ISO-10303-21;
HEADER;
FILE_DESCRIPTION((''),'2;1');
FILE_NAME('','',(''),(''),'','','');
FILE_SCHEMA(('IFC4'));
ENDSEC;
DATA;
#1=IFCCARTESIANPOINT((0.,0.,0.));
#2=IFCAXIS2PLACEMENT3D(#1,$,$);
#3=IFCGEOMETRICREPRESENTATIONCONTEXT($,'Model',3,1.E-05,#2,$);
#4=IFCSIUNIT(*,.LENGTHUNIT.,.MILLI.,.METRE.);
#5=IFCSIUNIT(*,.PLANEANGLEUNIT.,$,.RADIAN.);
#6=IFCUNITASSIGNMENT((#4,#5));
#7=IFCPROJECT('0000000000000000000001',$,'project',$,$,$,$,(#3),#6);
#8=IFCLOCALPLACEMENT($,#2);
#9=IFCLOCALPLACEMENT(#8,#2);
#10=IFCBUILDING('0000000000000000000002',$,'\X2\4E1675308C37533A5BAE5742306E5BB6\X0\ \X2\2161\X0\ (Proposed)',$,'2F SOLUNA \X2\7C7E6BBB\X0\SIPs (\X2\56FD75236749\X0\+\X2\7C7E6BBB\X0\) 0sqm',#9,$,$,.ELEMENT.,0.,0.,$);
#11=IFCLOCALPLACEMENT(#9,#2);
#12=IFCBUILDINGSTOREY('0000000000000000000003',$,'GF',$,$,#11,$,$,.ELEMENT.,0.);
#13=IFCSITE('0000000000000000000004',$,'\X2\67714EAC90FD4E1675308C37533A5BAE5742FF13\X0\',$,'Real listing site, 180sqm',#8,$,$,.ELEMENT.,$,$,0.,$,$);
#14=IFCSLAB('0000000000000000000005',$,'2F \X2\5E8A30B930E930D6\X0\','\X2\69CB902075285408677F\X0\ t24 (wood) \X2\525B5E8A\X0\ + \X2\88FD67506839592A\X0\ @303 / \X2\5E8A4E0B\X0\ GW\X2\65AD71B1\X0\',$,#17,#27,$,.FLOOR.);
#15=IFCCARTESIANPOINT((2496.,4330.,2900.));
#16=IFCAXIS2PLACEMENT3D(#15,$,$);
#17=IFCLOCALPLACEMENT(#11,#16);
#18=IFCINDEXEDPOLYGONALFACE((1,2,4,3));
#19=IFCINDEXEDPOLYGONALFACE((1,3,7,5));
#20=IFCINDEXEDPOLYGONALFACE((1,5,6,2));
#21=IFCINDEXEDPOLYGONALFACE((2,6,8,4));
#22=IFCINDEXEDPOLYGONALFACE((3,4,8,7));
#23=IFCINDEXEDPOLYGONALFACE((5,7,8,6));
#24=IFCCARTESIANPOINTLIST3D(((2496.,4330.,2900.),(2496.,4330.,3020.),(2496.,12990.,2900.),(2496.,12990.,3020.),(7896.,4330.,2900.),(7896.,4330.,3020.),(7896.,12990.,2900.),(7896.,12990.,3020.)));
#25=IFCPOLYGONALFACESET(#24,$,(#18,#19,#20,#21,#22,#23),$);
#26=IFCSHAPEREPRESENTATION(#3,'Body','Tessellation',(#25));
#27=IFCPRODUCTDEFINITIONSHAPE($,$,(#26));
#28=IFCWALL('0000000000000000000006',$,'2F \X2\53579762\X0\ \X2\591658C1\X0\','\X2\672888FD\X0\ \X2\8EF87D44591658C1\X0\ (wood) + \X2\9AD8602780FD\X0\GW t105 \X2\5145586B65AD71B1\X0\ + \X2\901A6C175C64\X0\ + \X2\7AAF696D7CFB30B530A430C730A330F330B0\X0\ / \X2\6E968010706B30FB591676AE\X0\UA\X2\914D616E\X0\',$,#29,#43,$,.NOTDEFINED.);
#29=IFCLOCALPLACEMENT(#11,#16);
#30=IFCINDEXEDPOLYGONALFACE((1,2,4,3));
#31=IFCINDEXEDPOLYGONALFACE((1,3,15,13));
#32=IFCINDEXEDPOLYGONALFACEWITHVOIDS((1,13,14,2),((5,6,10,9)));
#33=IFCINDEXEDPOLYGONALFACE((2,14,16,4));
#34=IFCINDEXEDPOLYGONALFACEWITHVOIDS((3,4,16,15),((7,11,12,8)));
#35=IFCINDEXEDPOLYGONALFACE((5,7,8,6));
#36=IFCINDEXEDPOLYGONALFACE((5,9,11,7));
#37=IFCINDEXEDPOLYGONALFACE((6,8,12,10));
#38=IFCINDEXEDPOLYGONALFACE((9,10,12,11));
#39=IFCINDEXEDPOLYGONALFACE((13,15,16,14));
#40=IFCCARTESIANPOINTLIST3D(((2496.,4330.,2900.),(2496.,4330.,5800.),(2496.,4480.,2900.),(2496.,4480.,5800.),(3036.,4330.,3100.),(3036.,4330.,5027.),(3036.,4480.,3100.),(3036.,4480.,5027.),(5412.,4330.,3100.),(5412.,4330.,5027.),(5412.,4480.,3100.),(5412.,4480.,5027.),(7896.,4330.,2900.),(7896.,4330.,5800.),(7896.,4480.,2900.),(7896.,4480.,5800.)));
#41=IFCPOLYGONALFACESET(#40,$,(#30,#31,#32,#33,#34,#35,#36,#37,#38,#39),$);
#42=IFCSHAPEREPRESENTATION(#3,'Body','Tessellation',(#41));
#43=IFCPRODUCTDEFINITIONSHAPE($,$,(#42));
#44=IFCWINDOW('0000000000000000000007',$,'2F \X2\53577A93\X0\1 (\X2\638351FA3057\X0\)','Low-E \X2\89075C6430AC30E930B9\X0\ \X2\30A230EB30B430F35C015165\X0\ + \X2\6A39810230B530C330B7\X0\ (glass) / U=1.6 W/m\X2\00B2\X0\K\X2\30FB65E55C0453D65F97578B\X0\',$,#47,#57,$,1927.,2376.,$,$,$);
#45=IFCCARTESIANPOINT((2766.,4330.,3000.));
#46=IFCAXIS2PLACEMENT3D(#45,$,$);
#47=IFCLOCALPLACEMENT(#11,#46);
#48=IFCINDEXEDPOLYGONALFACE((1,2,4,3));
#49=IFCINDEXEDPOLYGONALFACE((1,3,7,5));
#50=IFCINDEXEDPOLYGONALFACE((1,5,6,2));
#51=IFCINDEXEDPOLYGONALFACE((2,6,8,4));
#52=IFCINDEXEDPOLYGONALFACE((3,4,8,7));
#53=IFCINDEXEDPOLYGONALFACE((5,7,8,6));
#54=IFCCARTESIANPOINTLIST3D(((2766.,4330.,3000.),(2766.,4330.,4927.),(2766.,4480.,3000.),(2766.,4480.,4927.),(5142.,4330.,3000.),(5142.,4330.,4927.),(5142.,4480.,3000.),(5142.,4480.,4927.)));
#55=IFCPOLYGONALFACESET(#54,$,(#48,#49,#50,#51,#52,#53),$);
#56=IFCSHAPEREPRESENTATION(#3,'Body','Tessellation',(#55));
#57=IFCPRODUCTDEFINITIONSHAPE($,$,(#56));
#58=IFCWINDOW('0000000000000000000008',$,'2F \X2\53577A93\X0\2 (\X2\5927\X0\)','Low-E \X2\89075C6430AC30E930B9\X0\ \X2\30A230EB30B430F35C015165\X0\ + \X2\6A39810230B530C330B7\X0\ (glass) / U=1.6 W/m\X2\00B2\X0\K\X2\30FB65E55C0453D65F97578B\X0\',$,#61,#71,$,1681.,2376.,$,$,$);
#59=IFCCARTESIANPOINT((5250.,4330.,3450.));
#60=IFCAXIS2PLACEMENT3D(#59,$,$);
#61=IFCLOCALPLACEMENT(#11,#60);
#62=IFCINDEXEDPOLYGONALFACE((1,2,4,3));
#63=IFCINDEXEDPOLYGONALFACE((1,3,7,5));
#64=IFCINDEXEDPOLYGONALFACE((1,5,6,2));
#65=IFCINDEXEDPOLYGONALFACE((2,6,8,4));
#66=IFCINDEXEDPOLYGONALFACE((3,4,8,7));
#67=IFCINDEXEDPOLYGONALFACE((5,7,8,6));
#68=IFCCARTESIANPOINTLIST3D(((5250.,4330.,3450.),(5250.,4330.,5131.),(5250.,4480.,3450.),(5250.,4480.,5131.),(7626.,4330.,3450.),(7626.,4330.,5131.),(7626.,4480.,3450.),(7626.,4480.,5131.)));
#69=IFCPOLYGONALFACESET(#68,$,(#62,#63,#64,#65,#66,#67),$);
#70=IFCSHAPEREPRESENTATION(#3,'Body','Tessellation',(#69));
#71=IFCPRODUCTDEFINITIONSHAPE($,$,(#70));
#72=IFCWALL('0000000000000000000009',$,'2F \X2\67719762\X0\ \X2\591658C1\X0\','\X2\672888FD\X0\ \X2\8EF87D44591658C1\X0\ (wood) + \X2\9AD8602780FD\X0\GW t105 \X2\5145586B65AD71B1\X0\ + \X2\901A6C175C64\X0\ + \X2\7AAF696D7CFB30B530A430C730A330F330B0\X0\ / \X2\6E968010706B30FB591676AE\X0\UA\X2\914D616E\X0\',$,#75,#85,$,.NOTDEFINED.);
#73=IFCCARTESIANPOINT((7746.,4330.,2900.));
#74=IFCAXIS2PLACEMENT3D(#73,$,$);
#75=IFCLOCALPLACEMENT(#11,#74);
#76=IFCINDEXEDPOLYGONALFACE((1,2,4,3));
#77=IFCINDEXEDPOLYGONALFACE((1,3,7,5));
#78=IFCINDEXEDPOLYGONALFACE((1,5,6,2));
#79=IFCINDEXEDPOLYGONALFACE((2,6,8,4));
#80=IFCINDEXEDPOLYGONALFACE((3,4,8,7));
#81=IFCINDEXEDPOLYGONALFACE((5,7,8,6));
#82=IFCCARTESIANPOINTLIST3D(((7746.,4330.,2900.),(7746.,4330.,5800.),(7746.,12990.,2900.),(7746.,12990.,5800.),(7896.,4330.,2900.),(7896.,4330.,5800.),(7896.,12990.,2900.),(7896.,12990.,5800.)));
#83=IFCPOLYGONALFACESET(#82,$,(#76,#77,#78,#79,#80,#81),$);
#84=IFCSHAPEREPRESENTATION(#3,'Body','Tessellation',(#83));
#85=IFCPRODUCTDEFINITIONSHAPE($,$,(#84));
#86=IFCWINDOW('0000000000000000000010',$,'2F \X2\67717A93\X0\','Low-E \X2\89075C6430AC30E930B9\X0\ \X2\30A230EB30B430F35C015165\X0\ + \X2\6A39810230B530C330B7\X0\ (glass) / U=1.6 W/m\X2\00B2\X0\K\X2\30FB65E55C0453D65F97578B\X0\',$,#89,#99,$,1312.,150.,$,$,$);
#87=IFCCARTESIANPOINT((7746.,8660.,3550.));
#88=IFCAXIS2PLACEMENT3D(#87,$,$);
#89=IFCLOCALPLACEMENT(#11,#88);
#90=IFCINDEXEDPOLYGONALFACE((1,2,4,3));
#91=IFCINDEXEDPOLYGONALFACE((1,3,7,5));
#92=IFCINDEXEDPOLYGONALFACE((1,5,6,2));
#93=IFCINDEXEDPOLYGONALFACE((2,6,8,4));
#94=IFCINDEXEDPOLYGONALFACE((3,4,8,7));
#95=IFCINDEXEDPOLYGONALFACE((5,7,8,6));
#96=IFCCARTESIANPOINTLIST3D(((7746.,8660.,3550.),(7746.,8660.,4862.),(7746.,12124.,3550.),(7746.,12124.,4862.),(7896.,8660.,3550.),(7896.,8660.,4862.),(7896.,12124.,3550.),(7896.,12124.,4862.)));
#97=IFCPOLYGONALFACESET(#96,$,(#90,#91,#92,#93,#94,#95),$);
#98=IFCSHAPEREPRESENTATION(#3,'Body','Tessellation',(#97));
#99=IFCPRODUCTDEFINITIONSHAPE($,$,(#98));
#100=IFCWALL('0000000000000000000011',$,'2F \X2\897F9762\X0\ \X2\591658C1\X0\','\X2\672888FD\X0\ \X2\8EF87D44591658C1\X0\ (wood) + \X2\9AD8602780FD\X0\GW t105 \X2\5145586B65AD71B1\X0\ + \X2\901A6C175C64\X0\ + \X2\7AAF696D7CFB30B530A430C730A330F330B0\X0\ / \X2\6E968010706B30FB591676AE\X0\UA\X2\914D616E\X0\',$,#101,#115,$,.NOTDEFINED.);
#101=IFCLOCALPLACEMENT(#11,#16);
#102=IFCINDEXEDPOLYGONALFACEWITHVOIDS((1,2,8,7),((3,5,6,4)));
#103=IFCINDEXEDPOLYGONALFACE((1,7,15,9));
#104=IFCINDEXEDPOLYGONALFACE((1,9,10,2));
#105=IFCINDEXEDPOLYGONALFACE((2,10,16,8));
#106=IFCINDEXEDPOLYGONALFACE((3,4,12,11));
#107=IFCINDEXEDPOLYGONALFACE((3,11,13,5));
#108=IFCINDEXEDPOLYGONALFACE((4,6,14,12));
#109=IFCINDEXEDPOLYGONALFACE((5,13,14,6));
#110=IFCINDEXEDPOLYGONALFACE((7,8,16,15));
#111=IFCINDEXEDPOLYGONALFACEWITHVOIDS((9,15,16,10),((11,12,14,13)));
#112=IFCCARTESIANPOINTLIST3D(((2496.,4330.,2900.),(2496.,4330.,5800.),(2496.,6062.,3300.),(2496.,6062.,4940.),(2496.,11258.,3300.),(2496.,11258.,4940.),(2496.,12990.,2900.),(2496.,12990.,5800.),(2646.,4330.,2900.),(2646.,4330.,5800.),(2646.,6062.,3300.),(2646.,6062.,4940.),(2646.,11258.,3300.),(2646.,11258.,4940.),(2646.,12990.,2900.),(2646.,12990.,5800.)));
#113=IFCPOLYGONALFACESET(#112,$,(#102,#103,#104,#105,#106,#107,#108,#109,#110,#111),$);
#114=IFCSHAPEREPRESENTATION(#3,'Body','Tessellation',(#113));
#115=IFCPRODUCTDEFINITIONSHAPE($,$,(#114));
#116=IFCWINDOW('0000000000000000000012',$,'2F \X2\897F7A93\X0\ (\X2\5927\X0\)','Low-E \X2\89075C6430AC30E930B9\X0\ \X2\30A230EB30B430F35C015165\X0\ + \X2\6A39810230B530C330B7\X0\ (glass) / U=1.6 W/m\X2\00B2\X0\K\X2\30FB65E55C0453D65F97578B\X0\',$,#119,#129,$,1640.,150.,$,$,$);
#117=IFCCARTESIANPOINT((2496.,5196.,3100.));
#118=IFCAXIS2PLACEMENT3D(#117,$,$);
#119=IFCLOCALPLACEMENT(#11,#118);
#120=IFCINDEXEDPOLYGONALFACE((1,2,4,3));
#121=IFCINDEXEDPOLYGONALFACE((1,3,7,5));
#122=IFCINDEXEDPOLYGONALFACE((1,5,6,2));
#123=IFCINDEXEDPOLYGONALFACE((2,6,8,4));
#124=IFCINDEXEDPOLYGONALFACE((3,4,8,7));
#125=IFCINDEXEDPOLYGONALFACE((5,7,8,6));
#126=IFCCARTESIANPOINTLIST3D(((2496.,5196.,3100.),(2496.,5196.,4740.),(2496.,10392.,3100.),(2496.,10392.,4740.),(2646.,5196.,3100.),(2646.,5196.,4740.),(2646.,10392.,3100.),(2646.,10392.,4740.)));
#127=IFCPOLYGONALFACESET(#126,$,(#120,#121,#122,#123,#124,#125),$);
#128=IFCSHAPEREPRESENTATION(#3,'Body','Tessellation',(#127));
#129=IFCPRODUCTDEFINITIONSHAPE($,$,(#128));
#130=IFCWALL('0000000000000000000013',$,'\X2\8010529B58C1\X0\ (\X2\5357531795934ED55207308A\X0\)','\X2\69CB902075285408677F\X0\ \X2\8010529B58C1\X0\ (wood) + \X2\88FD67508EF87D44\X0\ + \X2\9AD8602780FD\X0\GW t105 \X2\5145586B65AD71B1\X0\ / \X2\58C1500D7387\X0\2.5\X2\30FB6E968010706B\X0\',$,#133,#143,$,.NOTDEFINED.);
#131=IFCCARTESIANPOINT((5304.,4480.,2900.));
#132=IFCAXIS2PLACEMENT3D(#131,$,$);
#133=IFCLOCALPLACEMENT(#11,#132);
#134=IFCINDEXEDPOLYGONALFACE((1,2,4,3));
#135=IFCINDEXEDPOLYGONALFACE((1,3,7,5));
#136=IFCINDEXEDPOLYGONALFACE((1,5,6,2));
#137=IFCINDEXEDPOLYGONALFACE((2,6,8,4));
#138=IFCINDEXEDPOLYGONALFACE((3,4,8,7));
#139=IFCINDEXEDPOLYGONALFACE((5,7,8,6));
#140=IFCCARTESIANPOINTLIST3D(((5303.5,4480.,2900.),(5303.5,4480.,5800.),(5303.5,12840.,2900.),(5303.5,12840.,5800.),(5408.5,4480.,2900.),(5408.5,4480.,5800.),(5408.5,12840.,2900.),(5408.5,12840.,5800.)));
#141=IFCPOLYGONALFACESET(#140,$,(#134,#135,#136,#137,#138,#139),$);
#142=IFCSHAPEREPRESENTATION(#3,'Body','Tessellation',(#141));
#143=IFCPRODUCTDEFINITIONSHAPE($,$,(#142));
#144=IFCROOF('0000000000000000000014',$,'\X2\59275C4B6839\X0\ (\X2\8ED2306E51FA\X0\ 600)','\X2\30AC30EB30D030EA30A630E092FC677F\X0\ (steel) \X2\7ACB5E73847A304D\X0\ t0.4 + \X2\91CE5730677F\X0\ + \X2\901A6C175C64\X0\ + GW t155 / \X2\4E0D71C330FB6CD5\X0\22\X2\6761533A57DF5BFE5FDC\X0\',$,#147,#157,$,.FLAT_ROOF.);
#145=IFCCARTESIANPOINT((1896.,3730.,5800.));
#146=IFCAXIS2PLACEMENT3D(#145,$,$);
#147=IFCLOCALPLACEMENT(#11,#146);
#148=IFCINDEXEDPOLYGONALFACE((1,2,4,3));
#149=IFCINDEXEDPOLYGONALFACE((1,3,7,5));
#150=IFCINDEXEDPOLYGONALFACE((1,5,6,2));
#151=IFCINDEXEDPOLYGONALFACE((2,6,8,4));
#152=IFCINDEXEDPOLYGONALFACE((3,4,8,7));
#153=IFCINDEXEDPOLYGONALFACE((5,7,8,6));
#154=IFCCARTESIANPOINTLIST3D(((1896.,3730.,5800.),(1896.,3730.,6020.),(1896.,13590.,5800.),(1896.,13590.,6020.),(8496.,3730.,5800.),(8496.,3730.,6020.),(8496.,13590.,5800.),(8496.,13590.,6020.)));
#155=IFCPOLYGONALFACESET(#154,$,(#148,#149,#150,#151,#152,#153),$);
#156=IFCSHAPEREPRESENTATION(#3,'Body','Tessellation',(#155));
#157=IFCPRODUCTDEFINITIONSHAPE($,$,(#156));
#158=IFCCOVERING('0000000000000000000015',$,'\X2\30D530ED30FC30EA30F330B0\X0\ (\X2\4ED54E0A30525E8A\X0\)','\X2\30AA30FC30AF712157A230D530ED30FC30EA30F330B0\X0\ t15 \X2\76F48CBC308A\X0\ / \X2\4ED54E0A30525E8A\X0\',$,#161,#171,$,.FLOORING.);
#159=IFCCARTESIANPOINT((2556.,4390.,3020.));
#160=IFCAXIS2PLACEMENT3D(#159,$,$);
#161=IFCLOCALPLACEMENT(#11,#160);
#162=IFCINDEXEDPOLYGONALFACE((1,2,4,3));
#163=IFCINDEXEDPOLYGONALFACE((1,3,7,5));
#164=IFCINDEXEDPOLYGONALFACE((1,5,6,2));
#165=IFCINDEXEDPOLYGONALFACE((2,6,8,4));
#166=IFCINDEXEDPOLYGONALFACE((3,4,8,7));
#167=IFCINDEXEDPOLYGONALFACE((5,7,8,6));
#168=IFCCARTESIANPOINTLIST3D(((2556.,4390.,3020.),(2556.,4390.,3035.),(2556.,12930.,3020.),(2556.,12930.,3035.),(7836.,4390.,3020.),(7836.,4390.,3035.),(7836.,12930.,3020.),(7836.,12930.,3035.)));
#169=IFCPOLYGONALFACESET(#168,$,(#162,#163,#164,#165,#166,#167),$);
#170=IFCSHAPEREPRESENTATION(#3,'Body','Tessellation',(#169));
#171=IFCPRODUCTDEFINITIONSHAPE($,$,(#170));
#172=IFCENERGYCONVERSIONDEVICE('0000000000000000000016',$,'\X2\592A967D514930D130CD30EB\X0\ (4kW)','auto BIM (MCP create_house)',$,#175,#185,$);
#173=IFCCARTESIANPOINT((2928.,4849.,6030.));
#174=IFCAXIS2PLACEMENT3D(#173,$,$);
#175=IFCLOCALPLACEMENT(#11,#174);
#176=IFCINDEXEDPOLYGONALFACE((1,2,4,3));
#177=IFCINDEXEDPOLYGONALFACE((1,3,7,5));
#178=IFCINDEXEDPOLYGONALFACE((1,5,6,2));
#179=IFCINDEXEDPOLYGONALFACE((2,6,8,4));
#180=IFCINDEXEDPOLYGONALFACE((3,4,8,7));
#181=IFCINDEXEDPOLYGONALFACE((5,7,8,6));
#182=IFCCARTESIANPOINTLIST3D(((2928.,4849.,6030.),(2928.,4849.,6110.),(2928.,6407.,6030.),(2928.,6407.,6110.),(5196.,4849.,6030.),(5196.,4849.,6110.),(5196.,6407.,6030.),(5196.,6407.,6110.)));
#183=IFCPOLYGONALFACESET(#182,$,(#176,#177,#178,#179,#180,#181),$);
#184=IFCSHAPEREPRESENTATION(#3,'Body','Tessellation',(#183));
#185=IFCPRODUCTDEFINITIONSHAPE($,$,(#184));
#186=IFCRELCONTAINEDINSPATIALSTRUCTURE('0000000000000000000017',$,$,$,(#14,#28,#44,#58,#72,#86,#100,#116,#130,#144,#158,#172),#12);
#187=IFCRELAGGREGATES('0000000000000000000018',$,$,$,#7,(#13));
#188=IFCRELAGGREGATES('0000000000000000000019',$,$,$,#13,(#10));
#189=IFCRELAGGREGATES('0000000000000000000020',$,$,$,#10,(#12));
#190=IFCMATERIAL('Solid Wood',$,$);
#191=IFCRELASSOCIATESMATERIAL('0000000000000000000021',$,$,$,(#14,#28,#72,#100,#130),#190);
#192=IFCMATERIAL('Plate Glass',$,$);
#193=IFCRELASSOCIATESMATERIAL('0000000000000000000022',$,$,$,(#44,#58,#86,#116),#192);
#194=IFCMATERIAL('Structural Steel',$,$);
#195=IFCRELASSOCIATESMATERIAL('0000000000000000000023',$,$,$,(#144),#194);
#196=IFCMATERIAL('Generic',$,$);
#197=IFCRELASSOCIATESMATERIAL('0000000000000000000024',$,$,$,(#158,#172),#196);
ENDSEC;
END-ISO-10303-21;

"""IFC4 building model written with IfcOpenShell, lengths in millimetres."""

from ifc_helpers import new_model, si_unit, frame, frame_2d, origin, place, context, project, spatial, rectangle, extrude, material, element, fill, save


model = new_model("IFC4")

# Units and contexts
model_context = context("Model", 3, precision=1e-05, world=origin())
ifc_project = project(units=[si_unit("LENGTHUNIT", "METRE", prefix="MILLI"), si_unit("PLANEANGLEUNIT", "RADIAN")], contexts=[model_context])

# Site, building, storey
site_placement = place(None, origin())
site = spatial("IfcSite", under=ifc_project, at=site_placement, Name="東京都世田谷区宮坂３", ObjectType="Real listing site, 180sqm", CompositionType="ELEMENT", RefElevation=0.0)
building_placement = place(site_placement, origin())
building = spatial("IfcBuilding", under=site, at=building_placement, Name="世田谷区宮坂の家 Ⅱ (Proposed)", ObjectType="2F SOLUNA 籾殻SIPs (国産杉+籾殻) 0sqm", CompositionType="ELEMENT", ElevationOfRefHeight=0.0, ElevationOfTerrain=0.0)
storey_placement = place(building_placement, origin())
storey = spatial("IfcBuildingStorey", under=building, at=storey_placement, Name="GF", CompositionType="ELEMENT", Elevation=0.0)

# Slab
ifc_material_1 = material(Name="Solid Wood")
slab_placement = place(storey_placement, frame((2496.0, 4330.0, 2900.0)))
element("IfcSlab", 1, at=slab_placement, inside=storey, material=ifc_material_1, Name="2F 床スラブ", Description="構造用合板 t24 (wood) 剛床 + 製材根太 @303 / 床下 GW断熱", PredefinedType="FLOOR", context=model_context, shape_type="SweptSolid", body=[
    extrude(rectangle(XDim=5400.0, YDim=8660.0, at=frame_2d((2700.0, 4330.0))), frame((2496.0, 4330.0, 2900.0)), (0.0, 0.0, 1.0), 120.0),
])

# Wall, openings, windows
wall_1_placement = place(storey_placement, frame((2496.0, 4330.0, 2900.0)))
wall_1 = element("IfcWall", 2, at=wall_1_placement, inside=storey, material=ifc_material_1, Name="2F 南面 外壁", Description="木製 軸組外壁 (wood) + 高性能GW t105 充填断熱 + 通気層 + 窯業系サイディング / 準耐火・外皮UA配慮", PredefinedType="NOTDEFINED", context=model_context, shape_type="SweptSolid", body=[
    extrude(rectangle(XDim=5400.0, YDim=150.0, at=frame_2d((2700.0, 75.0))), frame((2496.0, 4330.0, 2900.0)), (0.0, 0.0, 1.0), 2900.0),
])
opening_1_placement = place(storey_placement, frame((2766.0, 4330.0, 3000.0)))
opening_1 = element("IfcOpeningElement", 3, at=opening_1_placement, cuts=wall_1, PredefinedType="NOTDEFINED", context=model_context, shape_type="SweptSolid", body=[
    extrude(rectangle(XDim=2376.0, YDim=150.0, at=frame_2d((1188.0, 75.0))), frame((2766.0, 4330.0, 3000.0)), (0.0, 0.0, 1.0), 1927.0),
])
opening_2_placement = place(storey_placement, frame((5250.0, 4330.0, 3450.0)))
opening_2 = element("IfcOpeningElement", 4, at=opening_2_placement, cuts=wall_1, PredefinedType="NOTDEFINED", context=model_context, shape_type="SweptSolid", body=[
    extrude(rectangle(XDim=2376.0, YDim=150.0, at=frame_2d((1188.0, 75.0))), frame((5250.0, 4330.0, 3450.0)), (0.0, 0.0, 1.0), 1681.0),
])
ifc_material_2 = material(Name="Plate Glass")
window_1_placement = place(storey_placement, frame((2766.0, 4330.0, 3000.0)))
window_1 = element("IfcWindow", 5, at=window_1_placement, inside=storey, material=ifc_material_2, Name="2F 南窓1 (掃出し)", Description="Low-E 複層ガラス アルゴン封入 + 樹脂サッシ (glass) / U=1.6 W/m²K・日射取得型", OverallHeight=1927.0, OverallWidth=2376.0, context=model_context, shape_type="SweptSolid", body=[
    extrude(rectangle(XDim=2376.0, YDim=150.0, at=frame_2d((1188.0, 75.0))), frame((2766.0, 4330.0, 3000.0)), (0.0, 0.0, 1.0), 1927.0),
])
fill(opening_1, window_1)
window_2_placement = place(storey_placement, frame((5250.0, 4330.0, 3450.0)))
window_2 = element("IfcWindow", 6, at=window_2_placement, inside=storey, material=ifc_material_2, Name="2F 南窓2 (大)", Description="Low-E 複層ガラス アルゴン封入 + 樹脂サッシ (glass) / U=1.6 W/m²K・日射取得型", OverallHeight=1681.0, OverallWidth=2376.0, context=model_context, shape_type="SweptSolid", body=[
    extrude(rectangle(XDim=2376.0, YDim=150.0, at=frame_2d((1188.0, 75.0))), frame((5250.0, 4330.0, 3450.0)), (0.0, 0.0, 1.0), 1681.0),
])
fill(opening_2, window_2)

# Walls, openings, windows
wall_2_placement = place(storey_placement, frame((7746.0, 4330.0, 2900.0)))
wall_2 = element("IfcWall", 7, at=wall_2_placement, inside=storey, material=ifc_material_1, Name="2F 東面 外壁", Description="木製 軸組外壁 (wood) + 高性能GW t105 充填断熱 + 通気層 + 窯業系サイディング / 準耐火・外皮UA配慮", PredefinedType="NOTDEFINED", context=model_context, shape_type="SweptSolid", body=[
    extrude(rectangle(XDim=150.0, YDim=8660.0, at=frame_2d((75.0, 4330.0))), frame((7746.0, 4330.0, 2900.0)), (0.0, 0.0, 1.0), 2900.0),
])
opening_3_placement = place(storey_placement, frame((7746.0, 8660.0, 3550.0)))
opening_3 = element("IfcOpeningElement", 8, at=opening_3_placement, cuts=wall_2, PredefinedType="NOTDEFINED", context=model_context, shape_type="SweptSolid", body=[
    extrude(rectangle(XDim=150.0, YDim=3464.0, at=frame_2d((75.0, 1732.0))), frame((7746.0, 8660.0, 3550.0)), (0.0, 0.0, 1.0), 1312.0),
])
window_3_placement = place(storey_placement, frame((7746.0, 8660.0, 3550.0)))
window_3 = element("IfcWindow", 9, at=window_3_placement, inside=storey, material=ifc_material_2, Name="2F 東窓", Description="Low-E 複層ガラス アルゴン封入 + 樹脂サッシ (glass) / U=1.6 W/m²K・日射取得型", OverallHeight=1312.0, OverallWidth=150.0, context=model_context, shape_type="SweptSolid", body=[
    extrude(rectangle(XDim=150.0, YDim=3464.0, at=frame_2d((75.0, 1732.0))), frame((7746.0, 8660.0, 3550.0)), (0.0, 0.0, 1.0), 1312.0),
])
fill(opening_3, window_3)
wall_3_placement = place(storey_placement, frame((2496.0, 4330.0, 2900.0)))
wall_3 = element("IfcWall", 10, at=wall_3_placement, inside=storey, material=ifc_material_1, Name="2F 西面 外壁", Description="木製 軸組外壁 (wood) + 高性能GW t105 充填断熱 + 通気層 + 窯業系サイディング / 準耐火・外皮UA配慮", PredefinedType="NOTDEFINED", context=model_context, shape_type="SweptSolid", body=[
    extrude(rectangle(XDim=150.0, YDim=8660.0, at=frame_2d((75.0, 4330.0))), frame((2496.0, 4330.0, 2900.0)), (0.0, 0.0, 1.0), 2900.0),
])
opening_4_placement = place(storey_placement, frame((2496.0, 5196.0, 3100.0)))
opening_4 = element("IfcOpeningElement", 11, at=opening_4_placement, cuts=wall_3, PredefinedType="NOTDEFINED", context=model_context, shape_type="SweptSolid", body=[
    extrude(rectangle(XDim=150.0, YDim=5196.0, at=frame_2d((75.0, 2598.0))), frame((2496.0, 5196.0, 3100.0)), (0.0, 0.0, 1.0), 1640.0),
])
window_4_placement = place(storey_placement, frame((2496.0, 5196.0, 3100.0)))
window_4 = element("IfcWindow", 12, at=window_4_placement, inside=storey, material=ifc_material_2, Name="2F 西窓 (大)", Description="Low-E 複層ガラス アルゴン封入 + 樹脂サッシ (glass) / U=1.6 W/m²K・日射取得型", OverallHeight=1640.0, OverallWidth=150.0, context=model_context, shape_type="SweptSolid", body=[
    extrude(rectangle(XDim=150.0, YDim=5196.0, at=frame_2d((75.0, 2598.0))), frame((2496.0, 5196.0, 3100.0)), (0.0, 0.0, 1.0), 1640.0),
])
fill(opening_4, window_4)

# Wall
wall_4_placement = place(storey_placement, frame((5304.0, 4480.0, 2900.0)))
element("IfcWall", 13, at=wall_4_placement, inside=storey, material=ifc_material_1, Name="耐力壁 (南北間仕切り)", Description="構造用合板 耐力壁 (wood) + 製材軸組 + 高性能GW t105 充填断熱 / 壁倍率2.5・準耐火", PredefinedType="NOTDEFINED", context=model_context, shape_type="SweptSolid", body=[
    extrude(rectangle(XDim=105.0, YDim=8360.0, at=frame_2d((52.0, 4180.0))), frame((5304.0, 4480.0, 2900.0)), (0.0, 0.0, 1.0), 2900.0),
])

# Roof
ifc_material_3 = material(Name="Structural Steel")
roof_placement = place(storey_placement, frame((1896.0, 3730.0, 5800.0)))
element("IfcRoof", 14, at=roof_placement, inside=storey, material=ifc_material_3, Name="大屋根 (軒の出 600)", Description="ガルバリウム鋼板 (steel) 立平葺き t0.4 + 野地板 + 通気層 + GW t155 / 不燃・法22条区域対応", PredefinedType="FLAT_ROOF", context=model_context, shape_type="SweptSolid", body=[
    extrude(rectangle(XDim=6600.0, YDim=9860.0, at=frame_2d((3300.0, 4930.0))), frame((1896.0, 3730.0, 5800.0)), (0.0, 0.0, 1.0), 220.0),
])

# Covering
ifc_material_4 = material(Name="Generic")
covering_placement = place(storey_placement, frame((2556.0, 4390.0, 3020.0)))
element("IfcCovering", 15, at=covering_placement, inside=storey, material=ifc_material_4, Name="フローリング (仕上げ床)", Description="オーク無垢フローリング t15 直貼り / 仕上げ床", PredefinedType="FLOORING", context=model_context, shape_type="SweptSolid", body=[
    extrude(rectangle(XDim=5280.0, YDim=8540.0, at=frame_2d((2640.0, 4270.0))), frame((2556.0, 4390.0, 3020.0)), (0.0, 0.0, 1.0), 15.0),
])

# Energy conversion device
energy_conversion_device_placement = place(storey_placement, frame((2928.0, 4849.0, 6030.0)))
element("IfcEnergyConversionDevice", 16, at=energy_conversion_device_placement, inside=storey, material=ifc_material_4, Name="太陽光パネル (4kW)", Description="auto BIM (MCP create_house)", context=model_context, shape_type="SweptSolid", body=[
    extrude(rectangle(XDim=2268.0, YDim=1558.0, at=frame_2d((1134.0, 779.0))), frame((2928.0, 4849.0, 6030.0)), (0.0, 0.0, 1.0), 80.0),
])

save(model, "model.ifc")
